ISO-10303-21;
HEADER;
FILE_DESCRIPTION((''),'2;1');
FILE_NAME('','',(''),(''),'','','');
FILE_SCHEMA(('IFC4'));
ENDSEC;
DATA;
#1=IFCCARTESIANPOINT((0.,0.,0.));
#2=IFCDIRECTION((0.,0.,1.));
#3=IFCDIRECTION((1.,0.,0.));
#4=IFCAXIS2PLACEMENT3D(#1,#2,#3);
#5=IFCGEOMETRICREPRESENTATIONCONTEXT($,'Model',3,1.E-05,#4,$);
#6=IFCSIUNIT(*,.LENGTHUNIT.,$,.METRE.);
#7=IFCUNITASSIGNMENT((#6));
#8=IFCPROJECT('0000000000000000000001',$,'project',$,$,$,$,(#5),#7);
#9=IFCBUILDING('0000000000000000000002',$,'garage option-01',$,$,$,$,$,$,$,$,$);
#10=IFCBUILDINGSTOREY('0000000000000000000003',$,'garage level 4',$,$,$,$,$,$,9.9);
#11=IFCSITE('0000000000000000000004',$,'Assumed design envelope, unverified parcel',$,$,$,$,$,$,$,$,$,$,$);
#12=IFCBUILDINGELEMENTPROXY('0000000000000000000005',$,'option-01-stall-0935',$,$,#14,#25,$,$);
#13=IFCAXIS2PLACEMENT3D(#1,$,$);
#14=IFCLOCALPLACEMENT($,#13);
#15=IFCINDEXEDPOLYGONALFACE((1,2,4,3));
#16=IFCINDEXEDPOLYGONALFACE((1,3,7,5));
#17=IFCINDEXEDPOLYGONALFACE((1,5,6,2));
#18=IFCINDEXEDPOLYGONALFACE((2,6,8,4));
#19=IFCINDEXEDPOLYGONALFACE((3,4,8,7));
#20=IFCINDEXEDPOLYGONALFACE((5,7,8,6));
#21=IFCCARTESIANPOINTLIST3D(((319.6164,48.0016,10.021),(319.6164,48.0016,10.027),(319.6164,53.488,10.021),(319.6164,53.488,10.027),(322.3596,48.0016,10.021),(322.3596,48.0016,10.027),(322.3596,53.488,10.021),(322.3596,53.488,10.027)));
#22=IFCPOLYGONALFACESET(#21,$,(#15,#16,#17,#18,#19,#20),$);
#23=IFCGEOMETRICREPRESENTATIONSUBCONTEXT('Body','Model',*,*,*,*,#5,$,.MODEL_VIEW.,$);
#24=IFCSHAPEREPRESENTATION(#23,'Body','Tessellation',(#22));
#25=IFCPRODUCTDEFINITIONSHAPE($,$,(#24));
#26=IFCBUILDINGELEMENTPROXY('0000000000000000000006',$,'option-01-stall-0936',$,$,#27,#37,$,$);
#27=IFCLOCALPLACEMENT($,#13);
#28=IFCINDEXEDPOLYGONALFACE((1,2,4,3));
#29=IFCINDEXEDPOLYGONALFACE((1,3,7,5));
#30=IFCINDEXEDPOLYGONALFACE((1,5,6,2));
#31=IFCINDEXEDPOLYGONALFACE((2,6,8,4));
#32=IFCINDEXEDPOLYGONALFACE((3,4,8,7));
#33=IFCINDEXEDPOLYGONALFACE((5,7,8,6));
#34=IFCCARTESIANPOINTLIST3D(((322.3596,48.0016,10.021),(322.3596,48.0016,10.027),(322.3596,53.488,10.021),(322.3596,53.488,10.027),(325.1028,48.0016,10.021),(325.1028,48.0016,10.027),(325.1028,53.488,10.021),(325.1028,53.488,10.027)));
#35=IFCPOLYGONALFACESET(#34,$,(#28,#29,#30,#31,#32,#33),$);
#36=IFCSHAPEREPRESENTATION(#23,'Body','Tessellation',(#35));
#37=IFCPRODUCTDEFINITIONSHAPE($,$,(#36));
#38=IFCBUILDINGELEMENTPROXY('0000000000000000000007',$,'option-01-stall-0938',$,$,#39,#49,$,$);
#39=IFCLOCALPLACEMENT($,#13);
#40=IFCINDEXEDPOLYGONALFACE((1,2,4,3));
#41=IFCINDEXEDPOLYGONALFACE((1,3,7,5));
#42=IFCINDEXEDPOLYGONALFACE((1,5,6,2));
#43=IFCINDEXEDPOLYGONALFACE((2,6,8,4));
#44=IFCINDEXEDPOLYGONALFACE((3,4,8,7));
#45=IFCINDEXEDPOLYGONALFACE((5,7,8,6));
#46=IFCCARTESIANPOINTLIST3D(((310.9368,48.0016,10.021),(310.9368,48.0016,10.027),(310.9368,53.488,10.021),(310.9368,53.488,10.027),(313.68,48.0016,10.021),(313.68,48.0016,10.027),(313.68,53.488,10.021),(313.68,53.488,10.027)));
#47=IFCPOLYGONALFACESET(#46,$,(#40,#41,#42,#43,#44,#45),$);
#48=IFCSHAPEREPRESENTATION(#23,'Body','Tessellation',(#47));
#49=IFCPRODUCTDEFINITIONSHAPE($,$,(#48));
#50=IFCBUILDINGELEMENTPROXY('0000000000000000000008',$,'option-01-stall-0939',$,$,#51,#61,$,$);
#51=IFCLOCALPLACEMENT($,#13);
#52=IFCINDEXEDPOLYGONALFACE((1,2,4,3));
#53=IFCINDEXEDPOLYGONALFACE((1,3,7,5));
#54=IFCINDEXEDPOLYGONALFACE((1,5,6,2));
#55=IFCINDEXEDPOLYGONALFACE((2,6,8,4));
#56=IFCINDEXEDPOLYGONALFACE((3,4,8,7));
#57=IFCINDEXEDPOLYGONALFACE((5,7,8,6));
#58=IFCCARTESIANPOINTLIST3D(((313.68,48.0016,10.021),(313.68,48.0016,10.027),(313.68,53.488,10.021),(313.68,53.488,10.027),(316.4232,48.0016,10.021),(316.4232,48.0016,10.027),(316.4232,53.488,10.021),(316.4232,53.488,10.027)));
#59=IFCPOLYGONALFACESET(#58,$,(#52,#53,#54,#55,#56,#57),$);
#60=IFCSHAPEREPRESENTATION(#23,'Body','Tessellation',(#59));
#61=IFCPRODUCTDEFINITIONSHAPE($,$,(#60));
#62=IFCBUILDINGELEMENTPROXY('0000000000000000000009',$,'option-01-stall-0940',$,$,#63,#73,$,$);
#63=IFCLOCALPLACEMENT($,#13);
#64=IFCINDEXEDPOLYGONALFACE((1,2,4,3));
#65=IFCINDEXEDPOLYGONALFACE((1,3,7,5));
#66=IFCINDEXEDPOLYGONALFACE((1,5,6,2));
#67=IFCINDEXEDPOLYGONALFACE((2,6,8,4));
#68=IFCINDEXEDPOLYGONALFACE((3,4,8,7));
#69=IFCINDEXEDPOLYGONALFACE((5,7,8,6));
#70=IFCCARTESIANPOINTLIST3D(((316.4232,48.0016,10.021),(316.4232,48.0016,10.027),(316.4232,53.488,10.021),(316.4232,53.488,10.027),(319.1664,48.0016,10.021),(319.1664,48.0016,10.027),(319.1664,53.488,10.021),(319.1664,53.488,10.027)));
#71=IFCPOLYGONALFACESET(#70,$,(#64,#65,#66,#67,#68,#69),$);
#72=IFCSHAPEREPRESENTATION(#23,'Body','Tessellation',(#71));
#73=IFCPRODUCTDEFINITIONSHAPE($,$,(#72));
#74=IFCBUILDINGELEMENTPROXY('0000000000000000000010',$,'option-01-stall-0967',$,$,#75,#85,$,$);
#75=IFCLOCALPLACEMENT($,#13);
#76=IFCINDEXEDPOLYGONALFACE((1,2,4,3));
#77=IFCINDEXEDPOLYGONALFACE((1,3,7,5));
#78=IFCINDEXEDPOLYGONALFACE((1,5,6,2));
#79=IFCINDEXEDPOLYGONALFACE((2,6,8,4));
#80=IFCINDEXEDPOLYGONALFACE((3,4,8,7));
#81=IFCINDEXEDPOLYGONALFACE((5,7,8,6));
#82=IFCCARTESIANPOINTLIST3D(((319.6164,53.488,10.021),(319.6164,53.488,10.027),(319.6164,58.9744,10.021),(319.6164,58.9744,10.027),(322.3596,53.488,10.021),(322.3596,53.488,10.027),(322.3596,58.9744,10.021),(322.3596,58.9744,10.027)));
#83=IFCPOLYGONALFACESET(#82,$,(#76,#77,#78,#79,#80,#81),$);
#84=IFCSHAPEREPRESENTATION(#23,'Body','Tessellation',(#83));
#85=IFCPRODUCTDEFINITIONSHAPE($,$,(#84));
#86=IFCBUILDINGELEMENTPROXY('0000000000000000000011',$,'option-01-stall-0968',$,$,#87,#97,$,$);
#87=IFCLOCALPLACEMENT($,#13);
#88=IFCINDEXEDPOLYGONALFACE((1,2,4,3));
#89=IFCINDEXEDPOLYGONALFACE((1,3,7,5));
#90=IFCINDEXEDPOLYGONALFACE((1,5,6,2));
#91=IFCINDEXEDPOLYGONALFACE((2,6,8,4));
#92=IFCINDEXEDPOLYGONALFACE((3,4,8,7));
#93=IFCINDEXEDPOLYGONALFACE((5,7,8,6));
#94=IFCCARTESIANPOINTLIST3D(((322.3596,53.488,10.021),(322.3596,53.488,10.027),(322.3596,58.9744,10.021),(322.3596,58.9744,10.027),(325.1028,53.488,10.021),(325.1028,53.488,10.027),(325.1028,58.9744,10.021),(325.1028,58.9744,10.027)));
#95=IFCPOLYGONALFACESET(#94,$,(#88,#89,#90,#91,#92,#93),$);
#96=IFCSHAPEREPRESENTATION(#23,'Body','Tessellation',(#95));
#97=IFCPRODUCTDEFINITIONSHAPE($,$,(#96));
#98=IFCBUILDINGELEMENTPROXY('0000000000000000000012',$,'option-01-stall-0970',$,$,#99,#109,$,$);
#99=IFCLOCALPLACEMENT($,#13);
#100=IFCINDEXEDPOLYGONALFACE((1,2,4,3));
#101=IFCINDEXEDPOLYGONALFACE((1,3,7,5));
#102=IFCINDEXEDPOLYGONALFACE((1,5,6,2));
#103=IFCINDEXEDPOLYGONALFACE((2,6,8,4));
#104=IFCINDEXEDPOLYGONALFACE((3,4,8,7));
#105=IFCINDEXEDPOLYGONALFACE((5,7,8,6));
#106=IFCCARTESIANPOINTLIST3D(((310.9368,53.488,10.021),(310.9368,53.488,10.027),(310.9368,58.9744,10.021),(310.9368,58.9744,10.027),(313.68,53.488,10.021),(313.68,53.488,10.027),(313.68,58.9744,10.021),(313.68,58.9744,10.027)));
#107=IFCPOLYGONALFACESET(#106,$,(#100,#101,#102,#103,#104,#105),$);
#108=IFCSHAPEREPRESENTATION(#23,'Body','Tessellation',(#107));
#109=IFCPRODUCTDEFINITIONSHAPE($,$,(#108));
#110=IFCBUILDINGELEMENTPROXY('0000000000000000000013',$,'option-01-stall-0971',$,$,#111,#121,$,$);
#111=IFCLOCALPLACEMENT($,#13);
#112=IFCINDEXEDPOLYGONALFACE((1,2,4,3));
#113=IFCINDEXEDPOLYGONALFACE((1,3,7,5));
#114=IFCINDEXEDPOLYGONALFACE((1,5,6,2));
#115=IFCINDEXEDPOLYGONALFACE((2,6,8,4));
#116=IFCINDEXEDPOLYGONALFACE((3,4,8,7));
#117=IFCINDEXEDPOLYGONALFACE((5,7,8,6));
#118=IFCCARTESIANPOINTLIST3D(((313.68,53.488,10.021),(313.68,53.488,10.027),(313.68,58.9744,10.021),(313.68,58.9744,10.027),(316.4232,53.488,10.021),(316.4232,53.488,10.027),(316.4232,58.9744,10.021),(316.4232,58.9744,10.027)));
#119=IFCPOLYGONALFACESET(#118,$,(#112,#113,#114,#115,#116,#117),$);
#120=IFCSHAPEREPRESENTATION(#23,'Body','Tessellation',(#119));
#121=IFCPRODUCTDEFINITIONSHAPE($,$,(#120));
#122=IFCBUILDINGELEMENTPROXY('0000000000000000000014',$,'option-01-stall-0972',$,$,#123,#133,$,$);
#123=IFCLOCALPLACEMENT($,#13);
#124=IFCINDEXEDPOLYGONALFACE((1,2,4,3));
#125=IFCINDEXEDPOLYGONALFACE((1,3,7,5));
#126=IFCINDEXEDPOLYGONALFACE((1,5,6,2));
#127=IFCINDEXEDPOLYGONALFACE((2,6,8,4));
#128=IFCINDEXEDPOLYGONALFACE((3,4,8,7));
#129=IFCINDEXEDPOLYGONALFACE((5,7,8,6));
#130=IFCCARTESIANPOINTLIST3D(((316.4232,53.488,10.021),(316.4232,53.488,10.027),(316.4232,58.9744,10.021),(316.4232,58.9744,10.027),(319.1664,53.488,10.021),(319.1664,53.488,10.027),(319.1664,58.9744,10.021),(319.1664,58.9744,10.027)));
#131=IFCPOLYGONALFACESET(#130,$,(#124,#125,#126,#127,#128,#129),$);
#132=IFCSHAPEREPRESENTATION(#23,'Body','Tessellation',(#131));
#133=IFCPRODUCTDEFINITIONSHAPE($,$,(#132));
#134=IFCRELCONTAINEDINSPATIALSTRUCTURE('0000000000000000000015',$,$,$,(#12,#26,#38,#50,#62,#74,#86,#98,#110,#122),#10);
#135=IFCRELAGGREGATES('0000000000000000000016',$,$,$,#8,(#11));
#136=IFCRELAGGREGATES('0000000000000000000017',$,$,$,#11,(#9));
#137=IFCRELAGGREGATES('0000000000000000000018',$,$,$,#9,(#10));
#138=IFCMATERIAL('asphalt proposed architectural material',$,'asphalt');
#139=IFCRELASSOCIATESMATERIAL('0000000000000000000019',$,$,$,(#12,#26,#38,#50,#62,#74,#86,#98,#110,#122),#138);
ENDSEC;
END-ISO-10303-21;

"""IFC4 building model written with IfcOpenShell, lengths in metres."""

from ifc_helpers import new_model, si_unit, frame, origin_with_axes, place, context, subcontext, project, spatial, rectangle, extrude, material, element, save


model = new_model("IFC4")

# Units and contexts
model_context = context("Model", 3, precision=1e-05, world=origin_with_axes())
body_context = subcontext(model_context, "Body", "Model", "MODEL_VIEW")
ifc_project = project(units=[si_unit("LENGTHUNIT", "METRE")], contexts=[model_context])

# Site, building, storey
site = spatial("IfcSite", under=ifc_project, Name="Assumed design envelope, unverified parcel")
building = spatial("IfcBuilding", under=site, Name="garage option-01")
storey = spatial("IfcBuildingStorey", under=building, Name="garage level 4", Elevation=9.9)

# Building element proxies
ifc_material_1 = material(Name="asphalt proposed architectural material", Category="asphalt")
for number, where, z_axis, x_axis, name in (
    (1, (320.988, 50.7448, 10.021), (0.0, 0.0, 1.0), (1.0, 0.0, 0.0), "option-01-stall-0935"),
    (2, (323.7312, 50.7448, 10.021), (0.0, 0.0, 1.0), (1.0, 0.0, 0.0), "option-01-stall-0936"),
    (3, (312.3084, 50.7448, 10.021), (0.0, 0.0, 1.0), (1.0, 0.0, 0.0), "option-01-stall-0938"),
    (4, (315.0516, 50.7448, 10.021), (0.0, 0.0, 1.0), (1.0, 0.0, 0.0), "option-01-stall-0939"),
    (5, (317.7948, 50.7448, 10.021), (0.0, 0.0, 1.0), (1.0, 0.0, 0.0), "option-01-stall-0940"),
):
    element("IfcBuildingElementProxy", number, at=place(None, frame(where, z_axis=z_axis, x_axis=x_axis)), inside=storey, material=ifc_material_1, Name=name, context=body_context, shape_type="SweptSolid", body=[
        extrude(rectangle(XDim=2.7432, YDim=5.4864), origin_with_axes(), (0.0, 0.0, 1.0), 0.006),
    ])
for number, where, z_axis, x_axis, name in (
    (6, (320.988, 56.2312, 10.021), (0.0, 0.0, 1.0), (1.0, 0.0, 0.0), "option-01-stall-0967"),
    (7, (323.7312, 56.2312, 10.021), (0.0, 0.0, 1.0), (1.0, 0.0, 0.0), "option-01-stall-0968"),
    (8, (312.3084, 56.2312, 10.021), (0.0, 0.0, 1.0), (1.0, 0.0, 0.0), "option-01-stall-0970"),
    (9, (315.0516, 56.2312, 10.021), (0.0, 0.0, 1.0), (1.0, 0.0, 0.0), "option-01-stall-0971"),
    (10, (317.7948, 56.2312, 10.021), (0.0, 0.0, 1.0), (1.0, 0.0, 0.0), "option-01-stall-0972"),
):
    element("IfcBuildingElementProxy", number, at=place(None, frame(where, z_axis=z_axis, x_axis=x_axis)), inside=storey, material=ifc_material_1, Name=name, context=body_context, shape_type="SweptSolid", body=[
        extrude(rectangle(XDim=2.7432, YDim=5.4864), origin_with_axes(), (0.0, 0.0, 1.0), 0.006),
    ])

save(model, "model.ifc")
